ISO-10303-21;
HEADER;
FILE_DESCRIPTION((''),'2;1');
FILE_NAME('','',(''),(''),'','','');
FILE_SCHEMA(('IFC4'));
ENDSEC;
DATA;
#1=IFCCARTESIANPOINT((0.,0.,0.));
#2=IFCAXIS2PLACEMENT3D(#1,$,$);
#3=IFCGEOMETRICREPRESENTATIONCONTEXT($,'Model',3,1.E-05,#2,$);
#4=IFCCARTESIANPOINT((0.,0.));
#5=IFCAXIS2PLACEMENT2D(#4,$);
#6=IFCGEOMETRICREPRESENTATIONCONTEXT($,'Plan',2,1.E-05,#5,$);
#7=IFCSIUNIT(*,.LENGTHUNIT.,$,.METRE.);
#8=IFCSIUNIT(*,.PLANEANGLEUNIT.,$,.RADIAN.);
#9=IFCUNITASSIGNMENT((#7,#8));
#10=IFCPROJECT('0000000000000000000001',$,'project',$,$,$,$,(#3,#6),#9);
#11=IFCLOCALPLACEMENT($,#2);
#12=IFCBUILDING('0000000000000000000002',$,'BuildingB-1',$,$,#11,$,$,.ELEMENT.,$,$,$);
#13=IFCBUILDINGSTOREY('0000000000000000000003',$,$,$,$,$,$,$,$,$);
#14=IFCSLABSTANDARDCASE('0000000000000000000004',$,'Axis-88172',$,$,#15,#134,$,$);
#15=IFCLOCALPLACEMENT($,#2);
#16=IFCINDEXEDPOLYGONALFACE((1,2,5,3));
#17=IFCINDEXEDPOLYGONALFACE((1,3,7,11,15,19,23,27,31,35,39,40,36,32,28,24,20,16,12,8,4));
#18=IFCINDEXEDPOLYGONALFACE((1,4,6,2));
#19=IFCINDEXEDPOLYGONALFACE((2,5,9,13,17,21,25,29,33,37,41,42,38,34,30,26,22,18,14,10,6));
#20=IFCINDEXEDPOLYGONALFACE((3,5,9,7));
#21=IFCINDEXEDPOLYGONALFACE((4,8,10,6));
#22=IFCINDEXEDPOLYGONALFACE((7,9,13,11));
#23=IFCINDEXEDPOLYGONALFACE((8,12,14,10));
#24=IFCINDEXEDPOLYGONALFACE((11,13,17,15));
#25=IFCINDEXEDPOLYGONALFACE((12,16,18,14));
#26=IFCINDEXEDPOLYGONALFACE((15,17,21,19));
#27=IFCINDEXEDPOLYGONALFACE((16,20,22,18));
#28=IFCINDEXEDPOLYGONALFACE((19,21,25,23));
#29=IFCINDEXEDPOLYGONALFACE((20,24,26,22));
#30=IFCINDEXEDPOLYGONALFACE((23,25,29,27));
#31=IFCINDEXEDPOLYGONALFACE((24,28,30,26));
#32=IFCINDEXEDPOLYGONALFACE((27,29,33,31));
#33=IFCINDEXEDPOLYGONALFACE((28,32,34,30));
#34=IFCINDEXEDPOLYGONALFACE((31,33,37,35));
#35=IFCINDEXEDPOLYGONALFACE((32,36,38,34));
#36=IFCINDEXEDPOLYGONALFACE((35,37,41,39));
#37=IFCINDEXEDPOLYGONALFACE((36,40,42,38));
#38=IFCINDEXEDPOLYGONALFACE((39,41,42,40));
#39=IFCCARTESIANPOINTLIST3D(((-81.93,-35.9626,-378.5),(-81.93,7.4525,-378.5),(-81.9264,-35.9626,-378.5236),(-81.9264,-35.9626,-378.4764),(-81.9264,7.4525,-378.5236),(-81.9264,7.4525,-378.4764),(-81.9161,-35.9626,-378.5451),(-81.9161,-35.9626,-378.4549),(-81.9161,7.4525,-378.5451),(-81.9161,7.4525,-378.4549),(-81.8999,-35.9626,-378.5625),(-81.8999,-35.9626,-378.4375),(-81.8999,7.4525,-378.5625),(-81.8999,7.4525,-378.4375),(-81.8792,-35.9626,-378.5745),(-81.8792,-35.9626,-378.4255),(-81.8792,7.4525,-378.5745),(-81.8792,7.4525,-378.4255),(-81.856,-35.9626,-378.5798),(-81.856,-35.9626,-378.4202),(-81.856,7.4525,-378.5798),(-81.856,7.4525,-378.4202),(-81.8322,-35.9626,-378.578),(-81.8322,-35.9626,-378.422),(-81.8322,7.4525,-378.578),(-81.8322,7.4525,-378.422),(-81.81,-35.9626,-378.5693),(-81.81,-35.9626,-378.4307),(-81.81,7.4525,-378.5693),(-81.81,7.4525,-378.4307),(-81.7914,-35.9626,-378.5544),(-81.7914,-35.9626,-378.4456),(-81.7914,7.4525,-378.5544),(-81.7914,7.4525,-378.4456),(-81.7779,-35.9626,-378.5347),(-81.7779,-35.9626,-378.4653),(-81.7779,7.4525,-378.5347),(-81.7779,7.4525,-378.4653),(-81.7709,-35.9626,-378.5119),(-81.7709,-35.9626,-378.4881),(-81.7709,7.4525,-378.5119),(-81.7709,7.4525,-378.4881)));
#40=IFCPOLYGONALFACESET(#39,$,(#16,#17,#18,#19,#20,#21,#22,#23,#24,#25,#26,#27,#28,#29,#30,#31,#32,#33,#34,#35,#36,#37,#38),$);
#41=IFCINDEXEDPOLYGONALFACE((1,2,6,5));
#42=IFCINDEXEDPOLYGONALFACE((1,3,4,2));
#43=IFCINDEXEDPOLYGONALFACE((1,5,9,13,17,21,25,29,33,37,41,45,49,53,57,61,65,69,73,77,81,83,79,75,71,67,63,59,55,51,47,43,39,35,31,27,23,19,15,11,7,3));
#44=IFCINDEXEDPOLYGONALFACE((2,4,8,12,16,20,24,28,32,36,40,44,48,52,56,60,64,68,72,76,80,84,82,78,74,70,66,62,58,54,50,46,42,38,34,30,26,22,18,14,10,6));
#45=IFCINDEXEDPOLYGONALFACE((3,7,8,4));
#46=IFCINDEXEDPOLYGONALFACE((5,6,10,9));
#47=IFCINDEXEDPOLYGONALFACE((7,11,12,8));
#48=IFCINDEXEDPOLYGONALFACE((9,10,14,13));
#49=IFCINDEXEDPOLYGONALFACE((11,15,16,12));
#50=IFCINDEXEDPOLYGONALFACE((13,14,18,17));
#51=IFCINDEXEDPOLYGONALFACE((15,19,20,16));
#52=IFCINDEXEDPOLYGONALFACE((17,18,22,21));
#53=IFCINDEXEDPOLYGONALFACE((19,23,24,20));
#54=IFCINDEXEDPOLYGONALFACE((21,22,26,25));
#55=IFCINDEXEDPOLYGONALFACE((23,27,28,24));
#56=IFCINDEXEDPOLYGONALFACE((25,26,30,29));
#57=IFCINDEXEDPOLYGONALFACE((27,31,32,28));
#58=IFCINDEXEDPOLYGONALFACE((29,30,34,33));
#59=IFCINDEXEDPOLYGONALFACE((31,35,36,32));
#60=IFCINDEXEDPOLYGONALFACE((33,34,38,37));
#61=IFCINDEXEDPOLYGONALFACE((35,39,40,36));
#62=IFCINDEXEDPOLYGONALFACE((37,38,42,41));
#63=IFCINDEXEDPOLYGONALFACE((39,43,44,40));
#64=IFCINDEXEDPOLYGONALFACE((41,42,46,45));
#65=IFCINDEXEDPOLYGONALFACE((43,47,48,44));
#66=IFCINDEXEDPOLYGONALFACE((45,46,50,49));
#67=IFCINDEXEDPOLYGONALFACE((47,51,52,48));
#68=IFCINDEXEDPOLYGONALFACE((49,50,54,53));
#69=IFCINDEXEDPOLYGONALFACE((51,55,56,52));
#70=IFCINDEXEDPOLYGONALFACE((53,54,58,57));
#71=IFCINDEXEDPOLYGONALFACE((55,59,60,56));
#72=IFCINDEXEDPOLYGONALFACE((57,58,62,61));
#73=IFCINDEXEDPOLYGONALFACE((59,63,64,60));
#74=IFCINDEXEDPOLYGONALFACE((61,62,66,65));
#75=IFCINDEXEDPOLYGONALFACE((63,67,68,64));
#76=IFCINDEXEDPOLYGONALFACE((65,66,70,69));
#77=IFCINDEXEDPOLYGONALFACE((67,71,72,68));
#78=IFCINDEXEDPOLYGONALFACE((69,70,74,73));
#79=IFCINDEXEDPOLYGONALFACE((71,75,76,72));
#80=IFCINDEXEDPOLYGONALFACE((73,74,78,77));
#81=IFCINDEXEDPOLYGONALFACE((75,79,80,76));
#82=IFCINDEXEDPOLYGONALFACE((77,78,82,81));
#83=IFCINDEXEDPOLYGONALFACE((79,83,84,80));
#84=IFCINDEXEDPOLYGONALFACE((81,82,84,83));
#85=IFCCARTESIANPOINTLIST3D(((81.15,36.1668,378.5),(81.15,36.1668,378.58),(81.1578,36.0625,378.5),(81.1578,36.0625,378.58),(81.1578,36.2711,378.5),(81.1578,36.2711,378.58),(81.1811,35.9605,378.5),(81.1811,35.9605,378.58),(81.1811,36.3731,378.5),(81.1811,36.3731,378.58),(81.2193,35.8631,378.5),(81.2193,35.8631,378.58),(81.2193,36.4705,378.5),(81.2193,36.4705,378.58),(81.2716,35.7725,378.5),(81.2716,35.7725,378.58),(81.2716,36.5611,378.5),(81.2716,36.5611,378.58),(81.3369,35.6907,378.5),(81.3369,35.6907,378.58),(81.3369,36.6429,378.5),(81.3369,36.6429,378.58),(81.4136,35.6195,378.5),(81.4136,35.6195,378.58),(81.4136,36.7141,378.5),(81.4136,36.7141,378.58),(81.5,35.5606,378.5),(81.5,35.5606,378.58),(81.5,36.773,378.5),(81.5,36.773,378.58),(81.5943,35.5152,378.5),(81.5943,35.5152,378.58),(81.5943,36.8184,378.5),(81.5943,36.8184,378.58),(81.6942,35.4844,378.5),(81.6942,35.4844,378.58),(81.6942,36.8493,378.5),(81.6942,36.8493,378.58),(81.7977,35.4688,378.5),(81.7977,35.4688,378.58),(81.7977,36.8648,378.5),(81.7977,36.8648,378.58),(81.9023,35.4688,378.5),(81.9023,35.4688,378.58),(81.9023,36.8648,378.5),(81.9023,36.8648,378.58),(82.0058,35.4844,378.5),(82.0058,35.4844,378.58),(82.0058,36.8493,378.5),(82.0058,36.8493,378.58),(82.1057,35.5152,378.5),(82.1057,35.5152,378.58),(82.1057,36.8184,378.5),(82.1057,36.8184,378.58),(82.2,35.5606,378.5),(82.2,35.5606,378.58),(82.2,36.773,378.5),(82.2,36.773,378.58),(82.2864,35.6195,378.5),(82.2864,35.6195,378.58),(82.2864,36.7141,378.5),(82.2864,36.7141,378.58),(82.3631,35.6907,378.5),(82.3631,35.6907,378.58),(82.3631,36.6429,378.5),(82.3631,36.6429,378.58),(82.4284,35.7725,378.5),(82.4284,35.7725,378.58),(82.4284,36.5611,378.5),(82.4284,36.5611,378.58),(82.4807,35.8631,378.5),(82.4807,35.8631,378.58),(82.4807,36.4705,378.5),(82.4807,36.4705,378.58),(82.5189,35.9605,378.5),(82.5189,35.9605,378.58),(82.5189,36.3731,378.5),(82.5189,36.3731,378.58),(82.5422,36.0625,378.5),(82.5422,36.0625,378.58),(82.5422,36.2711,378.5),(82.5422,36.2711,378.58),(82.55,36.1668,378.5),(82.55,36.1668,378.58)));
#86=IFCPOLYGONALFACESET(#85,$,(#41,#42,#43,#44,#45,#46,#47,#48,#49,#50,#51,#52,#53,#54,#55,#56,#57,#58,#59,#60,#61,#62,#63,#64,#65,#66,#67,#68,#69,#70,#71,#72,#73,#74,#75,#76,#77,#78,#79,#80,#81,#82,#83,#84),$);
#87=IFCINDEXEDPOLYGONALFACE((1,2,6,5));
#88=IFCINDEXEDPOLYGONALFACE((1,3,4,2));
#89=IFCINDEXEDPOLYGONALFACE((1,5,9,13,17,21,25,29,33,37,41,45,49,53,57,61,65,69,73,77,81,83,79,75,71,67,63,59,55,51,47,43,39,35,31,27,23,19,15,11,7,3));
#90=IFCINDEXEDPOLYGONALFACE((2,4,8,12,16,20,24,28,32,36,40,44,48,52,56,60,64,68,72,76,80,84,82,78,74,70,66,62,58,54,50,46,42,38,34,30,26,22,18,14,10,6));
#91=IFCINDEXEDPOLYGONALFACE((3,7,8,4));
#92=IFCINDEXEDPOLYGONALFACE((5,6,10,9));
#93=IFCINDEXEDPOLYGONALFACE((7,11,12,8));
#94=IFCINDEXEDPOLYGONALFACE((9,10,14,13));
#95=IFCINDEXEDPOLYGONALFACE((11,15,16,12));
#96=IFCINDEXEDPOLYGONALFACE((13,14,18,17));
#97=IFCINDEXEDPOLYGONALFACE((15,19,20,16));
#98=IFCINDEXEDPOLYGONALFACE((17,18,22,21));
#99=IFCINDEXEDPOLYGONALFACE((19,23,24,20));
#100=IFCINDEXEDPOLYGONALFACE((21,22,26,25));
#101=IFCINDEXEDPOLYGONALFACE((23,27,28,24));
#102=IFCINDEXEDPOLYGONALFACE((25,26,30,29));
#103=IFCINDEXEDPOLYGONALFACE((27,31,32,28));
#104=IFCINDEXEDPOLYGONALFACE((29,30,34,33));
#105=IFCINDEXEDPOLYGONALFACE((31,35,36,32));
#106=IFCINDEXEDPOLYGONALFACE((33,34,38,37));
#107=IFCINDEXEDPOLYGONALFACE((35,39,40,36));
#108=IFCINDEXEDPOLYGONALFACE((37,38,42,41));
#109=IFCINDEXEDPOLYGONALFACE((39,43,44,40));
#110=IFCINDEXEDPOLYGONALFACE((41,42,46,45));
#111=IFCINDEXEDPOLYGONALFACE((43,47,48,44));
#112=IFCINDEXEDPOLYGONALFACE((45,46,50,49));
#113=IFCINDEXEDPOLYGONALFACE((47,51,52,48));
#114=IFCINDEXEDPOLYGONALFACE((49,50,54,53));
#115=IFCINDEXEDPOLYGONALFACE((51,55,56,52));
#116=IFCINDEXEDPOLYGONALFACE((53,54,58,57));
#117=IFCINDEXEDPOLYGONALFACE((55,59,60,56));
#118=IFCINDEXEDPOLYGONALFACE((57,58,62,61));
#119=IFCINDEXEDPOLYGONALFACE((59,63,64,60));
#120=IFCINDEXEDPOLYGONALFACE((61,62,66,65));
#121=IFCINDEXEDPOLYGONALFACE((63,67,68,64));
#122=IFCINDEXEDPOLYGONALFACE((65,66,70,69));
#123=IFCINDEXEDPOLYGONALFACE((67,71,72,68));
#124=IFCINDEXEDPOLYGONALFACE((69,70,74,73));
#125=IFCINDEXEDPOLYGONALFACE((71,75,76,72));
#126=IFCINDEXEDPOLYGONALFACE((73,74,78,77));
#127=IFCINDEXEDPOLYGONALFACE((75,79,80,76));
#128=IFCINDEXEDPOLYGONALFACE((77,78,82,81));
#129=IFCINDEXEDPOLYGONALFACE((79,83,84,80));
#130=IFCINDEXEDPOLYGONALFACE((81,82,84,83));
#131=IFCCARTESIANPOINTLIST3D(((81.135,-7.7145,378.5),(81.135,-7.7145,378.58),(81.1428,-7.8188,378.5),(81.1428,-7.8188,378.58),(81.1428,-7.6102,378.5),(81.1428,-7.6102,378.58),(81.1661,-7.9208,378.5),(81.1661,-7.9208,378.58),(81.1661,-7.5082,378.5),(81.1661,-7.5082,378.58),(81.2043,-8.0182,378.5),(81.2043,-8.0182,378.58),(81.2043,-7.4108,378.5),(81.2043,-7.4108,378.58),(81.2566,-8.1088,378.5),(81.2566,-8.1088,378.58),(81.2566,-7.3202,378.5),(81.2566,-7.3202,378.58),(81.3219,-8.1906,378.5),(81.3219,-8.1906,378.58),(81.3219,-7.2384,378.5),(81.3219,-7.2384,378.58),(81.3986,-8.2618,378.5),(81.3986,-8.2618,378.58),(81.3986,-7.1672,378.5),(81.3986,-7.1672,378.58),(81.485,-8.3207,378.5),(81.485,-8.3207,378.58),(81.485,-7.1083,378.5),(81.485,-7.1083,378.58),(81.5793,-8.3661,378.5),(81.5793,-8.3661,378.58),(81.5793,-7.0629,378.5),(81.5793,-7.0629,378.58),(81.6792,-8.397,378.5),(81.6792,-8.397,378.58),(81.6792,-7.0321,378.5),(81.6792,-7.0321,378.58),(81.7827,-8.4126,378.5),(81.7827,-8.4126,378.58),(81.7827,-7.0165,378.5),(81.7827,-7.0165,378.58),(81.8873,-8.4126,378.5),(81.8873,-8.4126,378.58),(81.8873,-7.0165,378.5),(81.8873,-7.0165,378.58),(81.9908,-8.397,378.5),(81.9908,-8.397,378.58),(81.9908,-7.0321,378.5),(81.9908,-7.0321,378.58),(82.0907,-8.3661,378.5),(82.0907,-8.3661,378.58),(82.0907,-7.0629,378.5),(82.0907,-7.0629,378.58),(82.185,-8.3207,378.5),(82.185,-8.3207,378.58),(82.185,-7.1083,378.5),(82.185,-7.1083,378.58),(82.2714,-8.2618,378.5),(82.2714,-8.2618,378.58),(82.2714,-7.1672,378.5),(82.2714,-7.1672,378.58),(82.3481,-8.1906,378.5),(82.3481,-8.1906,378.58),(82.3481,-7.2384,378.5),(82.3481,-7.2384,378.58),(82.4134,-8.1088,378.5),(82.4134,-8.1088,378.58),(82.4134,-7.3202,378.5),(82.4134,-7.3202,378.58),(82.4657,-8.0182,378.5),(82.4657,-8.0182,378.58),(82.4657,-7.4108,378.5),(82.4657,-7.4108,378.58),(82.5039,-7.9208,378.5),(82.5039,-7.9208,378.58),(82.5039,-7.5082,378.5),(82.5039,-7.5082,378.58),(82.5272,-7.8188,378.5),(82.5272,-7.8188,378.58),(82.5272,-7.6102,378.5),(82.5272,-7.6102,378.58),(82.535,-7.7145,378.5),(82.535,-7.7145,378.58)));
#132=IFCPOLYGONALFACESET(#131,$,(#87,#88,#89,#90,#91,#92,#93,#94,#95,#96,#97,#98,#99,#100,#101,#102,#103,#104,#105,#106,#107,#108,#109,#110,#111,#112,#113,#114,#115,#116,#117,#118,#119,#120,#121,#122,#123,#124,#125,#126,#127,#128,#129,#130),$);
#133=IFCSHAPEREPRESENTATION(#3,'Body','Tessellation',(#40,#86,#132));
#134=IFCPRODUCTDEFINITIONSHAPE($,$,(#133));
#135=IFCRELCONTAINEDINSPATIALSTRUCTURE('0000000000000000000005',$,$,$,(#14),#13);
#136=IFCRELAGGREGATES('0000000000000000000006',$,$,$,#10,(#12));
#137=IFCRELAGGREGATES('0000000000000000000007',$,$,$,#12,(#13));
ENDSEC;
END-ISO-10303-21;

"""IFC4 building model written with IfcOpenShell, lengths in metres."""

from ifc_helpers import new_model, entity, si_unit, frame, origin, origin_2d, place, context, project, spatial, circle, extrude, element, save


model = new_model("IFC4")

# Units and contexts
model_context = context("Model", 3, precision=1e-05, world=origin())
plan_context = context("Plan", 2, precision=1e-05, world=origin_2d())
ifc_project = project(units=[si_unit("LENGTHUNIT", "METRE"), si_unit("PLANEANGLEUNIT", "RADIAN")], contexts=[model_context, plan_context])

# Building, storey
building_placement = place(None, origin())
building = spatial("IfcBuilding", under=ifc_project, at=building_placement, Name="BuildingB-1", CompositionType="ELEMENT")
storey = spatial("IfcBuildingStorey", under=building)

# Slab
element("IfcSlabStandardCase", 1, inside=storey, Name="Axis-88172", context=model_context, shape_type="AdvancedSweptSolid", body=[
    entity("IfcSurfaceCurveSweptAreaSolid", entity("IfcCircleProfileDef", "AREA", None, None, 0.08), None, entity("IfcPolyline", [entity("IfcCartesianPoint", [81.85, 35.9626, 378.5]), entity("IfcCartesianPoint", [81.85, -7.4525, 378.5])]), None, None, entity("IfcPlane", entity("IfcAxis2Placement3D", entity("IfcCartesianPoint", [81.85, 35.9626, 378.5]), entity("IfcDirection", [0.0, 0.0, 1.0]), entity("IfcDirection", [1.0, 0.0, 0.0])))),
    extrude(circle(Radius=0.7), frame((81.85, 36.1668, 378.5)), (0.0, 0.0, 1.0), 0.08),
    extrude(circle(Radius=0.7), frame((81.835, -7.7145, 378.5)), (0.0, 0.0, 1.0), 0.08),
])

save(model, "model.ifc")
